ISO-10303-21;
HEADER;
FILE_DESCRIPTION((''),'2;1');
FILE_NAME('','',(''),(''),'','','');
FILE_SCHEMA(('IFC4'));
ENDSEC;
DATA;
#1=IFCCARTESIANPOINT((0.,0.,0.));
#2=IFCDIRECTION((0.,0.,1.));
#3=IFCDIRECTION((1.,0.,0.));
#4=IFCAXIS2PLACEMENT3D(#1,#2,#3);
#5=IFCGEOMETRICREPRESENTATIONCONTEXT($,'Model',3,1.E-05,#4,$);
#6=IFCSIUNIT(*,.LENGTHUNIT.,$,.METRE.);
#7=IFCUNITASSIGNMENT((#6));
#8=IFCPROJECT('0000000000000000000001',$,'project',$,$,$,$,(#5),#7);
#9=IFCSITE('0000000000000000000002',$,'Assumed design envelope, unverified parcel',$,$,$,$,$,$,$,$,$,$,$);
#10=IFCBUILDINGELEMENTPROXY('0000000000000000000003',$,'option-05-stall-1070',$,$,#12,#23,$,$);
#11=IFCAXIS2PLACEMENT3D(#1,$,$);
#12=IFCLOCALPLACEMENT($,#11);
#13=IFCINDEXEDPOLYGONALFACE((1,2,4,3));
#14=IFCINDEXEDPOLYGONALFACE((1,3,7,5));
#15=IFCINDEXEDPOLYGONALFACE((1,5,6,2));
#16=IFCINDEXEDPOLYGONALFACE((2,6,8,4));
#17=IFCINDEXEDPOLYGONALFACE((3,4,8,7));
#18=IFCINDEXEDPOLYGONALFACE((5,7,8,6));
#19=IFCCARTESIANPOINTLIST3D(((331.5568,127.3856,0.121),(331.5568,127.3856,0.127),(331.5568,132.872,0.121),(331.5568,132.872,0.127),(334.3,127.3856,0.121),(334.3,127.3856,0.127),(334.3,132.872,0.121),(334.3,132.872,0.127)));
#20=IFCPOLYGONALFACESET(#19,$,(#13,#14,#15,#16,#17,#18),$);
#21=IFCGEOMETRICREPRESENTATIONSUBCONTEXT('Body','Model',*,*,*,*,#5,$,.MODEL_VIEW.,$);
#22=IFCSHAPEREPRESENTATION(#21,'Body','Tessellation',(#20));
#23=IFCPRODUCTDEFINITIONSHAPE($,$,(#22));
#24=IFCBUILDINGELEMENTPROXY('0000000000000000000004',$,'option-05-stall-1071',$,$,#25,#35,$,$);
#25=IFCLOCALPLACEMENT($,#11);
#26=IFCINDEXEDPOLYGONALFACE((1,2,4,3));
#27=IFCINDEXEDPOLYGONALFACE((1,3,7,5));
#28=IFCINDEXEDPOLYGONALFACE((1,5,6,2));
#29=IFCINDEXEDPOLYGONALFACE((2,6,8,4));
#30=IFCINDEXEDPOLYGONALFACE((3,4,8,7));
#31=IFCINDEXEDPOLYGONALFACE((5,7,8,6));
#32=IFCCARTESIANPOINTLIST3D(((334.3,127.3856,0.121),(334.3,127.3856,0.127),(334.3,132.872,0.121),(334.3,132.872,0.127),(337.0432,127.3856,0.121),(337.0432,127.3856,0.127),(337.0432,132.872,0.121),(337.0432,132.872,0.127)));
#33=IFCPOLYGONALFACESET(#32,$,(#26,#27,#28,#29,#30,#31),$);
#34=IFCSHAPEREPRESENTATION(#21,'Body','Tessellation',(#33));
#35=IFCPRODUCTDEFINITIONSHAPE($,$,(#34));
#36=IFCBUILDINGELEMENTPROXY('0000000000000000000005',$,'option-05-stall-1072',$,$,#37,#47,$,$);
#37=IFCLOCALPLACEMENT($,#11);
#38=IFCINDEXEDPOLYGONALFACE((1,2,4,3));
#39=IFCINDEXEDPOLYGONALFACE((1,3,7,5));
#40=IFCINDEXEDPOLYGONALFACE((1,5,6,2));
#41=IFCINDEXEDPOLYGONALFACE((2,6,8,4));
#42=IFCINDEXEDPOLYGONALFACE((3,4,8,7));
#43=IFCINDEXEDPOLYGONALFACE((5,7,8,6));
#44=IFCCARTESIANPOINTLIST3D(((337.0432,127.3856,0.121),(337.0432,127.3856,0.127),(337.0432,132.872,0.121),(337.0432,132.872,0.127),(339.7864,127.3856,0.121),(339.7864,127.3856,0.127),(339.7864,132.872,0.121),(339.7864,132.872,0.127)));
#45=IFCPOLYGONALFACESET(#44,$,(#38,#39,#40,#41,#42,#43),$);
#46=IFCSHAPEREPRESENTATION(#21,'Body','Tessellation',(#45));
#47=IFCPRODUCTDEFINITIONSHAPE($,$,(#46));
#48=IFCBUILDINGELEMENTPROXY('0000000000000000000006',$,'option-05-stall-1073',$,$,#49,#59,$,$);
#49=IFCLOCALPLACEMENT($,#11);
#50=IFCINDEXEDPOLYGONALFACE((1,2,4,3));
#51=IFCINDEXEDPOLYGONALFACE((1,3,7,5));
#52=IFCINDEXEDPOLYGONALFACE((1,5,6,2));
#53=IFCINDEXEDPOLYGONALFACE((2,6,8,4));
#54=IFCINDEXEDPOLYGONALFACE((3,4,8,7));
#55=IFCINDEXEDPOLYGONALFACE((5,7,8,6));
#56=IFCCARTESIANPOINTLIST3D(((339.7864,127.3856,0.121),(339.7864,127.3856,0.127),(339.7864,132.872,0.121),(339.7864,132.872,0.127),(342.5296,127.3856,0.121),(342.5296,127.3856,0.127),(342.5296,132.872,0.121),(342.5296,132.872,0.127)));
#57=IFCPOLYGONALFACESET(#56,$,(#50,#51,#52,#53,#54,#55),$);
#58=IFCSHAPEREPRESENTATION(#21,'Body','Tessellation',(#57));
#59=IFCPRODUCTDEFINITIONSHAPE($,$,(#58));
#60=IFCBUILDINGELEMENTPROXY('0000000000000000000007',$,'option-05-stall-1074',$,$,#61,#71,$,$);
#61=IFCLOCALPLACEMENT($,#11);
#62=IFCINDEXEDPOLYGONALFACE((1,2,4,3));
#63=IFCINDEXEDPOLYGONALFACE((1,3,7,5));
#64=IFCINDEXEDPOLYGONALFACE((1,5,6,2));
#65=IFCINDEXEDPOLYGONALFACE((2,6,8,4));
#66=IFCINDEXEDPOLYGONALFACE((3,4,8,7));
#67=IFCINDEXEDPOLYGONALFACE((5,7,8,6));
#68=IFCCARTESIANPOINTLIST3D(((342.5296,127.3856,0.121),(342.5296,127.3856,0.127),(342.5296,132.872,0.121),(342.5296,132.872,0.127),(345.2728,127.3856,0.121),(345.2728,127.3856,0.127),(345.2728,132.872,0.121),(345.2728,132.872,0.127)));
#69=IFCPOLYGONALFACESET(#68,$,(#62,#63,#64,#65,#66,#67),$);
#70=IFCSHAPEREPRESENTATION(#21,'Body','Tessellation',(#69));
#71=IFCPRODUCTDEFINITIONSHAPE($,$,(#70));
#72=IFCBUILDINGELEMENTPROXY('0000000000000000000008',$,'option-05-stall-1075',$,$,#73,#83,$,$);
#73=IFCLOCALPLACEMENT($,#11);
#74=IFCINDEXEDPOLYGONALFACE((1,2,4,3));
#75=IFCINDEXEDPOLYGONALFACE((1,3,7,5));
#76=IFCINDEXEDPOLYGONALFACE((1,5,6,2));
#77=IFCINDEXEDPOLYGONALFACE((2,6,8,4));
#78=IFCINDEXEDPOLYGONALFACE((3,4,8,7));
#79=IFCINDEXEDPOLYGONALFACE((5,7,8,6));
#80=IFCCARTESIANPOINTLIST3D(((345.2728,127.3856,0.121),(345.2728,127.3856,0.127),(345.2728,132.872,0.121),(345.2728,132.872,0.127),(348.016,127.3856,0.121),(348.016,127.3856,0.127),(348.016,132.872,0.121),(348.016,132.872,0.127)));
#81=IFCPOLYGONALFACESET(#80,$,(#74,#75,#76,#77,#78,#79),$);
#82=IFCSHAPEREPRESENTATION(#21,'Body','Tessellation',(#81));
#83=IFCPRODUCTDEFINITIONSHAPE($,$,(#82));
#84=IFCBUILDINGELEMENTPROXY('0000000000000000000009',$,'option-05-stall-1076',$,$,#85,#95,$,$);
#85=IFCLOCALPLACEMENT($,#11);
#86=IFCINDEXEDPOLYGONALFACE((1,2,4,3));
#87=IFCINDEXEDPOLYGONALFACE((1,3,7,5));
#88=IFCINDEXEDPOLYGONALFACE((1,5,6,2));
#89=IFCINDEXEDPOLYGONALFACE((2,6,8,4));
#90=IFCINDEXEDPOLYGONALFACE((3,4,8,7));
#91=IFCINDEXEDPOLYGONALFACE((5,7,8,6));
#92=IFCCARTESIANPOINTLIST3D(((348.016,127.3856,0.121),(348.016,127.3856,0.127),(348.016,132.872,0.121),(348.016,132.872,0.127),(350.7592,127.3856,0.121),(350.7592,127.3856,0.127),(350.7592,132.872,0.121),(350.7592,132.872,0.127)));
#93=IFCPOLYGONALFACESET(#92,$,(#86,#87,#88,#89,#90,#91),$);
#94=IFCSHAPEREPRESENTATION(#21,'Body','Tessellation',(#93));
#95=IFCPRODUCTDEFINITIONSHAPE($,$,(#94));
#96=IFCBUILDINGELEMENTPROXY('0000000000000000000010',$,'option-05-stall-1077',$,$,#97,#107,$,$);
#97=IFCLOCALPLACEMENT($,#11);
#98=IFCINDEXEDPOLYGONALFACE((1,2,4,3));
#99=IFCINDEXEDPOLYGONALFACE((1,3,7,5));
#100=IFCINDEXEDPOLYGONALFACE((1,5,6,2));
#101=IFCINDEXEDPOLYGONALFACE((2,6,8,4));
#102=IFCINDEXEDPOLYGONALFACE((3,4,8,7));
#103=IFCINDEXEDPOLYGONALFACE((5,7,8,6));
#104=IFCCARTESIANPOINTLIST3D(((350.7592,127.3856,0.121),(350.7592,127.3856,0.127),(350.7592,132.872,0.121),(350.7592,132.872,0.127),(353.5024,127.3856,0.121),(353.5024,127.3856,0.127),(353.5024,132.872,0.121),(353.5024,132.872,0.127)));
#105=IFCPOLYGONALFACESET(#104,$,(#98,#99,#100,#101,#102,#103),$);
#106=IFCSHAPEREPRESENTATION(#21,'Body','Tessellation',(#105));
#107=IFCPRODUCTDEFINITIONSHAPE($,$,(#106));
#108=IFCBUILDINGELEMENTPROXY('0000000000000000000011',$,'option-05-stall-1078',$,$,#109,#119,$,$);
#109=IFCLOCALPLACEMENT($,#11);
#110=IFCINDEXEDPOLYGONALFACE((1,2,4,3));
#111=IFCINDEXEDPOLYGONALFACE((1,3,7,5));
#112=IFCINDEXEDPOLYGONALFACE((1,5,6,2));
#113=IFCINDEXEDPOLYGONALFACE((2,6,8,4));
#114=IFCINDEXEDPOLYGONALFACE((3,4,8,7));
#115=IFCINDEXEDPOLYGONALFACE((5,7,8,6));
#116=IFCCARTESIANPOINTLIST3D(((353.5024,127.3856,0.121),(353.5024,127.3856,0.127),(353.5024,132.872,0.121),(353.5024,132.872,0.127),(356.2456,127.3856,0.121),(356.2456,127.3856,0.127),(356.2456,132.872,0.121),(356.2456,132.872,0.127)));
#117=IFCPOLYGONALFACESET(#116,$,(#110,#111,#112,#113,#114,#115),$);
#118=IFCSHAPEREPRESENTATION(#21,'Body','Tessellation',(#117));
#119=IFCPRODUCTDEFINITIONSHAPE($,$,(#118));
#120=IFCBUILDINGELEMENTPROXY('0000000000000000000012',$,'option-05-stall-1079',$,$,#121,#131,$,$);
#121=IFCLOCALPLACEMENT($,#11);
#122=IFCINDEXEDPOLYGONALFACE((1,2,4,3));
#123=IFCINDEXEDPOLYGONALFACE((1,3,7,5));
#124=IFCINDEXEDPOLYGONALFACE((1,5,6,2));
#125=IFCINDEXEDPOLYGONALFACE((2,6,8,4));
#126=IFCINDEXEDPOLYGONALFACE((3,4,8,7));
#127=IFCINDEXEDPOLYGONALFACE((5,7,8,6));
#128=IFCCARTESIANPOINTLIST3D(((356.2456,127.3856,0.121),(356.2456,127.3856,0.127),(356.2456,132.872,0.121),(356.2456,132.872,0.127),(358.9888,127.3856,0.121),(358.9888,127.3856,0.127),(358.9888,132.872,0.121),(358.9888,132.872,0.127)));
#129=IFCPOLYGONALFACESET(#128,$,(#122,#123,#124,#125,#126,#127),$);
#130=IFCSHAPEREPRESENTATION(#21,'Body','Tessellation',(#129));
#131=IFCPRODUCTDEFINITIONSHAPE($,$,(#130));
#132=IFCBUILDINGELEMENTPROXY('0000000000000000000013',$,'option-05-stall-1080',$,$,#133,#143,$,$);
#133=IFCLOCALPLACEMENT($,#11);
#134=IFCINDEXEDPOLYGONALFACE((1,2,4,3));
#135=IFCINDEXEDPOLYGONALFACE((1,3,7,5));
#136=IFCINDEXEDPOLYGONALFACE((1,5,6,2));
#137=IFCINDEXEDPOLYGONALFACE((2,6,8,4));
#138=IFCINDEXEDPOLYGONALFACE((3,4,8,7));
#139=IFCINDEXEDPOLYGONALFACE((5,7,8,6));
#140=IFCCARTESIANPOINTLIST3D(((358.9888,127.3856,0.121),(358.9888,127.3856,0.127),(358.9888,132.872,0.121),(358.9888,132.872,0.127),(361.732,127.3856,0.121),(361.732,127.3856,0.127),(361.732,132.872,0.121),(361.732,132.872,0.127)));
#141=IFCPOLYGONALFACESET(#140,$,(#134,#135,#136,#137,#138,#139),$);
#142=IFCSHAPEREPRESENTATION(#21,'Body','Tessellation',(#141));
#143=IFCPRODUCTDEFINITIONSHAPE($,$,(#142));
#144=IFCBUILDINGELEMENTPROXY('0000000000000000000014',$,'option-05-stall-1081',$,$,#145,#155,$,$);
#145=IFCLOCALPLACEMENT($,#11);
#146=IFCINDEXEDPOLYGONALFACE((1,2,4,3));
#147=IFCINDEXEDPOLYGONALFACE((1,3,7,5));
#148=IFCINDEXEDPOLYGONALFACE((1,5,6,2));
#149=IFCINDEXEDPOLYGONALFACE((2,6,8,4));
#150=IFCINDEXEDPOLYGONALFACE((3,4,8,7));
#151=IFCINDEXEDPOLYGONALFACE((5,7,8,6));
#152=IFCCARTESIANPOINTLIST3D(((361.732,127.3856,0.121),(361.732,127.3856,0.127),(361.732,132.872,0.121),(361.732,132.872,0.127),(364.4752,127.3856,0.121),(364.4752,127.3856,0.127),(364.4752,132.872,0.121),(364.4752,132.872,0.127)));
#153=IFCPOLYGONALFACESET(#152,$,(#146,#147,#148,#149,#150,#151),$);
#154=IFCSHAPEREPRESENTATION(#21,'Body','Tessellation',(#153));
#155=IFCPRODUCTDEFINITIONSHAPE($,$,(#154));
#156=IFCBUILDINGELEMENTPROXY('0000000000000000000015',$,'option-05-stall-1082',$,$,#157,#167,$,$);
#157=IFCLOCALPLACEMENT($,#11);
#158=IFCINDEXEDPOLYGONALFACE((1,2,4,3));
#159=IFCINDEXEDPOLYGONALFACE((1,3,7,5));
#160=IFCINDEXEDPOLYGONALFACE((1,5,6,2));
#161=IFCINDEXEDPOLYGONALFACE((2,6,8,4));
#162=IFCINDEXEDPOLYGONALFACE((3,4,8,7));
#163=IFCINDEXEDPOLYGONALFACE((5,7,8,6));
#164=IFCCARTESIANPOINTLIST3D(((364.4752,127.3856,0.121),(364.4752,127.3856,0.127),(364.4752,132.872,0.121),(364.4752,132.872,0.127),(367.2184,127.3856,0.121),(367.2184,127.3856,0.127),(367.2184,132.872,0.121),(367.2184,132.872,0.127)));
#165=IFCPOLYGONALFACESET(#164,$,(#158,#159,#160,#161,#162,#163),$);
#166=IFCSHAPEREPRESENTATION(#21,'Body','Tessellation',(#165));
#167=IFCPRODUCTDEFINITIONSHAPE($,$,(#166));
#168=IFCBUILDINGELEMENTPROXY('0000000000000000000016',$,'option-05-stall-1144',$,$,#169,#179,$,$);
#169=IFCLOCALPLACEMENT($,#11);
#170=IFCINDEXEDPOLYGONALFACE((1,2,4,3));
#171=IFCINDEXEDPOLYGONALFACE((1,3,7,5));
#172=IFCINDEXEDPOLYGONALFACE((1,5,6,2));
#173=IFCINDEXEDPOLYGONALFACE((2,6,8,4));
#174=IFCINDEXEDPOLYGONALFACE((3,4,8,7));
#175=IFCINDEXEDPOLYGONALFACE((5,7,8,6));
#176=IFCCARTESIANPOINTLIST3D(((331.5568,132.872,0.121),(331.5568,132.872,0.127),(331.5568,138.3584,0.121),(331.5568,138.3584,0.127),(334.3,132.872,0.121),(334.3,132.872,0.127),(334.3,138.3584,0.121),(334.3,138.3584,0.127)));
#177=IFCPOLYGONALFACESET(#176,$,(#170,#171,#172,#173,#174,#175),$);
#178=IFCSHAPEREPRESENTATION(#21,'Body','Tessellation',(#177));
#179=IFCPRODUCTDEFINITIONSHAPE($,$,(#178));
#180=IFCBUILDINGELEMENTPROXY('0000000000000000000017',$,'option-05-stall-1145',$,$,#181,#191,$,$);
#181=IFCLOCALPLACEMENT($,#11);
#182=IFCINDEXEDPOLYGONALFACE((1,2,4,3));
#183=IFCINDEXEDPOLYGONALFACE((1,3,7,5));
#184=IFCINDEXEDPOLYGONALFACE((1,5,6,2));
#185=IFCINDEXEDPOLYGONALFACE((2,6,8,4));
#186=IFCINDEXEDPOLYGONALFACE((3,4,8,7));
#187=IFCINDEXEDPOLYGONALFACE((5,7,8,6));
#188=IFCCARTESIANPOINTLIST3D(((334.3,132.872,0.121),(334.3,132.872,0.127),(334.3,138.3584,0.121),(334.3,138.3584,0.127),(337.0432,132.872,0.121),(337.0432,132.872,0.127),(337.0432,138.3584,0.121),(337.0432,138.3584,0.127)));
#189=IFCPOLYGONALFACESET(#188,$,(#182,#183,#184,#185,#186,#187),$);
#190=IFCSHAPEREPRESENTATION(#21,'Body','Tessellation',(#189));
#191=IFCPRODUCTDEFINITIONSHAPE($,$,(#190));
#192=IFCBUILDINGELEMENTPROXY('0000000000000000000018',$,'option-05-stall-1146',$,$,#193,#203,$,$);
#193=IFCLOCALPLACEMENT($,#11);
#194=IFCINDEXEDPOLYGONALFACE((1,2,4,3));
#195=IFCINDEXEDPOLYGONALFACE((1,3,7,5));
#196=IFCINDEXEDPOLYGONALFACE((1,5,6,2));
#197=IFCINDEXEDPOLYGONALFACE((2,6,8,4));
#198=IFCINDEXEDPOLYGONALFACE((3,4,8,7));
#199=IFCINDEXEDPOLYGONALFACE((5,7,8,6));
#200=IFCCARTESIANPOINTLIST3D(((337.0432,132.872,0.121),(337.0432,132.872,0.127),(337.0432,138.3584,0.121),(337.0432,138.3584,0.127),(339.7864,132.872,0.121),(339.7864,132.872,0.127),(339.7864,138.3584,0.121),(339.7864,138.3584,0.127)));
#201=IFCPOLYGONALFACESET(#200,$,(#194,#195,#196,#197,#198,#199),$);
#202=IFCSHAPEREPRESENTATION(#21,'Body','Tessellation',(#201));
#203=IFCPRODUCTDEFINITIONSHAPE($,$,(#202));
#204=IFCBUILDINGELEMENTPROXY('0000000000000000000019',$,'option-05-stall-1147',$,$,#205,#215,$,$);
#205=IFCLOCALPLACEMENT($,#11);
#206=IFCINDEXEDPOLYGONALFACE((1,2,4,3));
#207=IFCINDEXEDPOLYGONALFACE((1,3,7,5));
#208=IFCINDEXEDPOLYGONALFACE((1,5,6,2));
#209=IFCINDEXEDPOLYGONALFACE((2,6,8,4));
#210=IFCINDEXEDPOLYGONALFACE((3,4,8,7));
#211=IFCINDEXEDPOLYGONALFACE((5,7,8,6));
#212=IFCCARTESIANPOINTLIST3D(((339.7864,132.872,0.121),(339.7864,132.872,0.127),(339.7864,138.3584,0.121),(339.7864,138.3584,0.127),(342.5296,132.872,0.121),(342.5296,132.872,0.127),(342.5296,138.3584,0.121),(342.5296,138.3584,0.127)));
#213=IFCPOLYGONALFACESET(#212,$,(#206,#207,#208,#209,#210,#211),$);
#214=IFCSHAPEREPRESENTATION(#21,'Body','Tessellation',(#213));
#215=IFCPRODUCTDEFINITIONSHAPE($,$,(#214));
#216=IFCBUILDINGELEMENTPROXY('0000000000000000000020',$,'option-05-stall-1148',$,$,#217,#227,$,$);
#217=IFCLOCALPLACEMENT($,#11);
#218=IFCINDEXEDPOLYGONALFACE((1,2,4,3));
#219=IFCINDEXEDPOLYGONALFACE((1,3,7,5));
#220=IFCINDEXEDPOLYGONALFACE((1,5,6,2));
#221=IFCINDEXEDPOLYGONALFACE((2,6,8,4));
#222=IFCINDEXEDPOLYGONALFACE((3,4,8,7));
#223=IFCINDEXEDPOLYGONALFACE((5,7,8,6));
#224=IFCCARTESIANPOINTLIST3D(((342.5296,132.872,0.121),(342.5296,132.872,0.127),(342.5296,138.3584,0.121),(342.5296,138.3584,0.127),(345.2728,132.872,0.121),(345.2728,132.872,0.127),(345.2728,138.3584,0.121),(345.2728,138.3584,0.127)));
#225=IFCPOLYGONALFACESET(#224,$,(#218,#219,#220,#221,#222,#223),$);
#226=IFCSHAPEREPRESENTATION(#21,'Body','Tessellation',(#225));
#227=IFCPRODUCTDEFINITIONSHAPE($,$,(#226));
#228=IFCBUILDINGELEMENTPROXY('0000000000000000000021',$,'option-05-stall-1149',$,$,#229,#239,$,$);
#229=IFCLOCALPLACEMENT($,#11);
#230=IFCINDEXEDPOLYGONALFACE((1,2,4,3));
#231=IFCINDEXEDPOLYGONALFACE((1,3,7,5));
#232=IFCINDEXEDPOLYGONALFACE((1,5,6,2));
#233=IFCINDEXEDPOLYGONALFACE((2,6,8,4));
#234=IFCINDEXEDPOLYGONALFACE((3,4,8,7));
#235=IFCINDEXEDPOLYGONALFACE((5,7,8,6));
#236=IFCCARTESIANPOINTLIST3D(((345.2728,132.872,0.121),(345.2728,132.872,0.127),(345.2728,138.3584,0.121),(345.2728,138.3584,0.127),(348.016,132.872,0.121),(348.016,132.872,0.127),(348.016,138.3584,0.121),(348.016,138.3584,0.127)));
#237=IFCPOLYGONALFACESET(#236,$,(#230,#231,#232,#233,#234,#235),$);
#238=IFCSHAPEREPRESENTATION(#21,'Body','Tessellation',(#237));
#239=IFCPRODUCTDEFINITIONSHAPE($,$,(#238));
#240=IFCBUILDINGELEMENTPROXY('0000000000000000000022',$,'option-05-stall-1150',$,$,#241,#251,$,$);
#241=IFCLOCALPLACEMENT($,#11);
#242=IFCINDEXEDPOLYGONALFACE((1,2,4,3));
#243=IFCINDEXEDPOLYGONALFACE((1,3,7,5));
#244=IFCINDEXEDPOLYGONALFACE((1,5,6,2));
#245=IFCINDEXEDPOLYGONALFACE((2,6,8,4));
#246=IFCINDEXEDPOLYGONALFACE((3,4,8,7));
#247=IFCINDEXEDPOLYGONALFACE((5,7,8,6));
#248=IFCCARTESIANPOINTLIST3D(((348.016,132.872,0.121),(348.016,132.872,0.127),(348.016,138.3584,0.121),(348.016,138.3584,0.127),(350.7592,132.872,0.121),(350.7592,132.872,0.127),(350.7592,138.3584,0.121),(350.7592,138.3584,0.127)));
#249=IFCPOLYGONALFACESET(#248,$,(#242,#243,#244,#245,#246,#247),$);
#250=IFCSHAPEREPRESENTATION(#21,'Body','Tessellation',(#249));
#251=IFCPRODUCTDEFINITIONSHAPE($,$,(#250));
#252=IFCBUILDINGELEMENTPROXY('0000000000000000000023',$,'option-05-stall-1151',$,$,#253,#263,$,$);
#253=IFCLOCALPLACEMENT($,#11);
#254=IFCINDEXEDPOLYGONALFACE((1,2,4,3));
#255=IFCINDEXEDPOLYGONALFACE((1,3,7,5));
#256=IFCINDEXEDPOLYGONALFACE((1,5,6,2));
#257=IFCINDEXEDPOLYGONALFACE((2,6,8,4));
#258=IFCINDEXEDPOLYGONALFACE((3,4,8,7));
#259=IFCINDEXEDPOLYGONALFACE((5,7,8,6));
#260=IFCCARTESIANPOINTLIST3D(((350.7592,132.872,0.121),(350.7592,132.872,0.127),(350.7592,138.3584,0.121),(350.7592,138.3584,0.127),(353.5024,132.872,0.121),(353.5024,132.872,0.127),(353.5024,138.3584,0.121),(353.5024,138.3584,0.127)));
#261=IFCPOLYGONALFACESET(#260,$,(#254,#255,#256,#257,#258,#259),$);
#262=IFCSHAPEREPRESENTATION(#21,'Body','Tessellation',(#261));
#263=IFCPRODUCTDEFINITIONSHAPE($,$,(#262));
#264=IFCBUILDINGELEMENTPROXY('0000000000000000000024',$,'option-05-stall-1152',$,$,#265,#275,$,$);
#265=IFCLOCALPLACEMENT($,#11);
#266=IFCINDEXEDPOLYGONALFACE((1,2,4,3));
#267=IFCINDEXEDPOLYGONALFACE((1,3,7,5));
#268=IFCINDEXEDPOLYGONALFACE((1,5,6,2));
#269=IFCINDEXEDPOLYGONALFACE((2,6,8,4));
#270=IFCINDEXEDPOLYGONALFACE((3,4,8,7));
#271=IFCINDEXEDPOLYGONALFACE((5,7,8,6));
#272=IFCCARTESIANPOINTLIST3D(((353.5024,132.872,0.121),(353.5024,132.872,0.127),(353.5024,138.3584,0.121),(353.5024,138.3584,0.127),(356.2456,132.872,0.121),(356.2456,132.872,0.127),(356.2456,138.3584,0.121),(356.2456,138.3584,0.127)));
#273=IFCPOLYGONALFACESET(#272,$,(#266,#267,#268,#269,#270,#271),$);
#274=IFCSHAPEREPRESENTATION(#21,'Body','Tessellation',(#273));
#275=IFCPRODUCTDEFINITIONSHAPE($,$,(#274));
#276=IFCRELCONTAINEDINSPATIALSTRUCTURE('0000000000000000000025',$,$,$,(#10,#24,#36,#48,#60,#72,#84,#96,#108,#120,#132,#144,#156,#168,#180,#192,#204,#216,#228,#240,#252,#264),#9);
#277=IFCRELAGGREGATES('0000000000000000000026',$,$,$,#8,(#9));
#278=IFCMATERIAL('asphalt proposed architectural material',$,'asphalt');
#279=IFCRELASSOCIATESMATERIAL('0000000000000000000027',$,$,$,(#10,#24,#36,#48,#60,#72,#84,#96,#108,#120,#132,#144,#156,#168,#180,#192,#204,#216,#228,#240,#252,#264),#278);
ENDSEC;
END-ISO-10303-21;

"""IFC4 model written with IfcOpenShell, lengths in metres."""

from ifc_helpers import new_model, si_unit, frame, origin_with_axes, place, context, subcontext, project, spatial, rectangle, extrude, material, element, save


model = new_model("IFC4")

# Units and contexts
model_context = context("Model", 3, precision=1e-05, world=origin_with_axes())
body_context = subcontext(model_context, "Body", "Model", "MODEL_VIEW")
ifc_project = project(units=[si_unit("LENGTHUNIT", "METRE")], contexts=[model_context])

# Site
site = spatial("IfcSite", under=ifc_project, Name="Assumed design envelope, unverified parcel")

# Building element proxies
ifc_material = material(Name="asphalt proposed architectural material", Category="asphalt")
for number, where, z_axis, x_axis, name in (
    (1, (332.9284, 130.1288, 0.121), (0.0, 0.0, 1.0), (1.0, 0.0, 0.0), "option-05-stall-1070"),
    (2, (335.6716, 130.1288, 0.121), (0.0, 0.0, 1.0), (1.0, 0.0, 0.0), "option-05-stall-1071"),
    (3, (338.4148, 130.1288, 0.121), (0.0, 0.0, 1.0), (1.0, 0.0, 0.0), "option-05-stall-1072"),
    (4, (341.158, 130.1288, 0.121), (0.0, 0.0, 1.0), (1.0, 0.0, 0.0), "option-05-stall-1073"),
    (5, (343.9012, 130.1288, 0.121), (0.0, 0.0, 1.0), (1.0, 0.0, 0.0), "option-05-stall-1074"),
    (6, (346.6444, 130.1288, 0.121), (0.0, 0.0, 1.0), (1.0, 0.0, 0.0), "option-05-stall-1075"),
    (7, (349.3876, 130.1288, 0.121), (0.0, 0.0, 1.0), (1.0, 0.0, 0.0), "option-05-stall-1076"),
    (8, (352.1308, 130.1288, 0.121), (0.0, 0.0, 1.0), (1.0, 0.0, 0.0), "option-05-stall-1077"),
    (9, (354.874, 130.1288, 0.121), (0.0, 0.0, 1.0), (1.0, 0.0, 0.0), "option-05-stall-1078"),
    (10, (357.6172, 130.1288, 0.121), (0.0, 0.0, 1.0), (1.0, 0.0, 0.0), "option-05-stall-1079"),
    (11, (360.3604, 130.1288, 0.121), (0.0, 0.0, 1.0), (1.0, 0.0, 0.0), "option-05-stall-1080"),
    (12, (363.1036, 130.1288, 0.121), (0.0, 0.0, 1.0), (1.0, 0.0, 0.0), "option-05-stall-1081"),
    (13, (365.8468, 130.1288, 0.121), (0.0, 0.0, 1.0), (1.0, 0.0, 0.0), "option-05-stall-1082"),
    (14, (332.9284, 135.6152, 0.121), (0.0, 0.0, 1.0), (1.0, 0.0, 0.0), "option-05-stall-1144"),
    (15, (335.6716, 135.6152, 0.121), (0.0, 0.0, 1.0), (1.0, 0.0, 0.0), "option-05-stall-1145"),
    (16, (338.4148, 135.6152, 0.121), (0.0, 0.0, 1.0), (1.0, 0.0, 0.0), "option-05-stall-1146"),
    (17, (341.158, 135.6152, 0.121), (0.0, 0.0, 1.0), (1.0, 0.0, 0.0), "option-05-stall-1147"),
    (18, (343.9012, 135.6152, 0.121), (0.0, 0.0, 1.0), (1.0, 0.0, 0.0), "option-05-stall-1148"),
    (19, (346.6444, 135.6152, 0.121), (0.0, 0.0, 1.0), (1.0, 0.0, 0.0), "option-05-stall-1149"),
    (20, (349.3876, 135.6152, 0.121), (0.0, 0.0, 1.0), (1.0, 0.0, 0.0), "option-05-stall-1150"),
    (21, (352.1308, 135.6152, 0.121), (0.0, 0.0, 1.0), (1.0, 0.0, 0.0), "option-05-stall-1151"),
    (22, (354.874, 135.6152, 0.121), (0.0, 0.0, 1.0), (1.0, 0.0, 0.0), "option-05-stall-1152"),
):
    element("IfcBuildingElementProxy", number, at=place(None, frame(where, z_axis=z_axis, x_axis=x_axis)), inside=site, material=ifc_material, Name=name, context=body_context, shape_type="SweptSolid", body=[
        extrude(rectangle(XDim=2.7432, YDim=5.4864), origin_with_axes(), (0.0, 0.0, 1.0), 0.006),
    ])

save(model, "model.ifc")
